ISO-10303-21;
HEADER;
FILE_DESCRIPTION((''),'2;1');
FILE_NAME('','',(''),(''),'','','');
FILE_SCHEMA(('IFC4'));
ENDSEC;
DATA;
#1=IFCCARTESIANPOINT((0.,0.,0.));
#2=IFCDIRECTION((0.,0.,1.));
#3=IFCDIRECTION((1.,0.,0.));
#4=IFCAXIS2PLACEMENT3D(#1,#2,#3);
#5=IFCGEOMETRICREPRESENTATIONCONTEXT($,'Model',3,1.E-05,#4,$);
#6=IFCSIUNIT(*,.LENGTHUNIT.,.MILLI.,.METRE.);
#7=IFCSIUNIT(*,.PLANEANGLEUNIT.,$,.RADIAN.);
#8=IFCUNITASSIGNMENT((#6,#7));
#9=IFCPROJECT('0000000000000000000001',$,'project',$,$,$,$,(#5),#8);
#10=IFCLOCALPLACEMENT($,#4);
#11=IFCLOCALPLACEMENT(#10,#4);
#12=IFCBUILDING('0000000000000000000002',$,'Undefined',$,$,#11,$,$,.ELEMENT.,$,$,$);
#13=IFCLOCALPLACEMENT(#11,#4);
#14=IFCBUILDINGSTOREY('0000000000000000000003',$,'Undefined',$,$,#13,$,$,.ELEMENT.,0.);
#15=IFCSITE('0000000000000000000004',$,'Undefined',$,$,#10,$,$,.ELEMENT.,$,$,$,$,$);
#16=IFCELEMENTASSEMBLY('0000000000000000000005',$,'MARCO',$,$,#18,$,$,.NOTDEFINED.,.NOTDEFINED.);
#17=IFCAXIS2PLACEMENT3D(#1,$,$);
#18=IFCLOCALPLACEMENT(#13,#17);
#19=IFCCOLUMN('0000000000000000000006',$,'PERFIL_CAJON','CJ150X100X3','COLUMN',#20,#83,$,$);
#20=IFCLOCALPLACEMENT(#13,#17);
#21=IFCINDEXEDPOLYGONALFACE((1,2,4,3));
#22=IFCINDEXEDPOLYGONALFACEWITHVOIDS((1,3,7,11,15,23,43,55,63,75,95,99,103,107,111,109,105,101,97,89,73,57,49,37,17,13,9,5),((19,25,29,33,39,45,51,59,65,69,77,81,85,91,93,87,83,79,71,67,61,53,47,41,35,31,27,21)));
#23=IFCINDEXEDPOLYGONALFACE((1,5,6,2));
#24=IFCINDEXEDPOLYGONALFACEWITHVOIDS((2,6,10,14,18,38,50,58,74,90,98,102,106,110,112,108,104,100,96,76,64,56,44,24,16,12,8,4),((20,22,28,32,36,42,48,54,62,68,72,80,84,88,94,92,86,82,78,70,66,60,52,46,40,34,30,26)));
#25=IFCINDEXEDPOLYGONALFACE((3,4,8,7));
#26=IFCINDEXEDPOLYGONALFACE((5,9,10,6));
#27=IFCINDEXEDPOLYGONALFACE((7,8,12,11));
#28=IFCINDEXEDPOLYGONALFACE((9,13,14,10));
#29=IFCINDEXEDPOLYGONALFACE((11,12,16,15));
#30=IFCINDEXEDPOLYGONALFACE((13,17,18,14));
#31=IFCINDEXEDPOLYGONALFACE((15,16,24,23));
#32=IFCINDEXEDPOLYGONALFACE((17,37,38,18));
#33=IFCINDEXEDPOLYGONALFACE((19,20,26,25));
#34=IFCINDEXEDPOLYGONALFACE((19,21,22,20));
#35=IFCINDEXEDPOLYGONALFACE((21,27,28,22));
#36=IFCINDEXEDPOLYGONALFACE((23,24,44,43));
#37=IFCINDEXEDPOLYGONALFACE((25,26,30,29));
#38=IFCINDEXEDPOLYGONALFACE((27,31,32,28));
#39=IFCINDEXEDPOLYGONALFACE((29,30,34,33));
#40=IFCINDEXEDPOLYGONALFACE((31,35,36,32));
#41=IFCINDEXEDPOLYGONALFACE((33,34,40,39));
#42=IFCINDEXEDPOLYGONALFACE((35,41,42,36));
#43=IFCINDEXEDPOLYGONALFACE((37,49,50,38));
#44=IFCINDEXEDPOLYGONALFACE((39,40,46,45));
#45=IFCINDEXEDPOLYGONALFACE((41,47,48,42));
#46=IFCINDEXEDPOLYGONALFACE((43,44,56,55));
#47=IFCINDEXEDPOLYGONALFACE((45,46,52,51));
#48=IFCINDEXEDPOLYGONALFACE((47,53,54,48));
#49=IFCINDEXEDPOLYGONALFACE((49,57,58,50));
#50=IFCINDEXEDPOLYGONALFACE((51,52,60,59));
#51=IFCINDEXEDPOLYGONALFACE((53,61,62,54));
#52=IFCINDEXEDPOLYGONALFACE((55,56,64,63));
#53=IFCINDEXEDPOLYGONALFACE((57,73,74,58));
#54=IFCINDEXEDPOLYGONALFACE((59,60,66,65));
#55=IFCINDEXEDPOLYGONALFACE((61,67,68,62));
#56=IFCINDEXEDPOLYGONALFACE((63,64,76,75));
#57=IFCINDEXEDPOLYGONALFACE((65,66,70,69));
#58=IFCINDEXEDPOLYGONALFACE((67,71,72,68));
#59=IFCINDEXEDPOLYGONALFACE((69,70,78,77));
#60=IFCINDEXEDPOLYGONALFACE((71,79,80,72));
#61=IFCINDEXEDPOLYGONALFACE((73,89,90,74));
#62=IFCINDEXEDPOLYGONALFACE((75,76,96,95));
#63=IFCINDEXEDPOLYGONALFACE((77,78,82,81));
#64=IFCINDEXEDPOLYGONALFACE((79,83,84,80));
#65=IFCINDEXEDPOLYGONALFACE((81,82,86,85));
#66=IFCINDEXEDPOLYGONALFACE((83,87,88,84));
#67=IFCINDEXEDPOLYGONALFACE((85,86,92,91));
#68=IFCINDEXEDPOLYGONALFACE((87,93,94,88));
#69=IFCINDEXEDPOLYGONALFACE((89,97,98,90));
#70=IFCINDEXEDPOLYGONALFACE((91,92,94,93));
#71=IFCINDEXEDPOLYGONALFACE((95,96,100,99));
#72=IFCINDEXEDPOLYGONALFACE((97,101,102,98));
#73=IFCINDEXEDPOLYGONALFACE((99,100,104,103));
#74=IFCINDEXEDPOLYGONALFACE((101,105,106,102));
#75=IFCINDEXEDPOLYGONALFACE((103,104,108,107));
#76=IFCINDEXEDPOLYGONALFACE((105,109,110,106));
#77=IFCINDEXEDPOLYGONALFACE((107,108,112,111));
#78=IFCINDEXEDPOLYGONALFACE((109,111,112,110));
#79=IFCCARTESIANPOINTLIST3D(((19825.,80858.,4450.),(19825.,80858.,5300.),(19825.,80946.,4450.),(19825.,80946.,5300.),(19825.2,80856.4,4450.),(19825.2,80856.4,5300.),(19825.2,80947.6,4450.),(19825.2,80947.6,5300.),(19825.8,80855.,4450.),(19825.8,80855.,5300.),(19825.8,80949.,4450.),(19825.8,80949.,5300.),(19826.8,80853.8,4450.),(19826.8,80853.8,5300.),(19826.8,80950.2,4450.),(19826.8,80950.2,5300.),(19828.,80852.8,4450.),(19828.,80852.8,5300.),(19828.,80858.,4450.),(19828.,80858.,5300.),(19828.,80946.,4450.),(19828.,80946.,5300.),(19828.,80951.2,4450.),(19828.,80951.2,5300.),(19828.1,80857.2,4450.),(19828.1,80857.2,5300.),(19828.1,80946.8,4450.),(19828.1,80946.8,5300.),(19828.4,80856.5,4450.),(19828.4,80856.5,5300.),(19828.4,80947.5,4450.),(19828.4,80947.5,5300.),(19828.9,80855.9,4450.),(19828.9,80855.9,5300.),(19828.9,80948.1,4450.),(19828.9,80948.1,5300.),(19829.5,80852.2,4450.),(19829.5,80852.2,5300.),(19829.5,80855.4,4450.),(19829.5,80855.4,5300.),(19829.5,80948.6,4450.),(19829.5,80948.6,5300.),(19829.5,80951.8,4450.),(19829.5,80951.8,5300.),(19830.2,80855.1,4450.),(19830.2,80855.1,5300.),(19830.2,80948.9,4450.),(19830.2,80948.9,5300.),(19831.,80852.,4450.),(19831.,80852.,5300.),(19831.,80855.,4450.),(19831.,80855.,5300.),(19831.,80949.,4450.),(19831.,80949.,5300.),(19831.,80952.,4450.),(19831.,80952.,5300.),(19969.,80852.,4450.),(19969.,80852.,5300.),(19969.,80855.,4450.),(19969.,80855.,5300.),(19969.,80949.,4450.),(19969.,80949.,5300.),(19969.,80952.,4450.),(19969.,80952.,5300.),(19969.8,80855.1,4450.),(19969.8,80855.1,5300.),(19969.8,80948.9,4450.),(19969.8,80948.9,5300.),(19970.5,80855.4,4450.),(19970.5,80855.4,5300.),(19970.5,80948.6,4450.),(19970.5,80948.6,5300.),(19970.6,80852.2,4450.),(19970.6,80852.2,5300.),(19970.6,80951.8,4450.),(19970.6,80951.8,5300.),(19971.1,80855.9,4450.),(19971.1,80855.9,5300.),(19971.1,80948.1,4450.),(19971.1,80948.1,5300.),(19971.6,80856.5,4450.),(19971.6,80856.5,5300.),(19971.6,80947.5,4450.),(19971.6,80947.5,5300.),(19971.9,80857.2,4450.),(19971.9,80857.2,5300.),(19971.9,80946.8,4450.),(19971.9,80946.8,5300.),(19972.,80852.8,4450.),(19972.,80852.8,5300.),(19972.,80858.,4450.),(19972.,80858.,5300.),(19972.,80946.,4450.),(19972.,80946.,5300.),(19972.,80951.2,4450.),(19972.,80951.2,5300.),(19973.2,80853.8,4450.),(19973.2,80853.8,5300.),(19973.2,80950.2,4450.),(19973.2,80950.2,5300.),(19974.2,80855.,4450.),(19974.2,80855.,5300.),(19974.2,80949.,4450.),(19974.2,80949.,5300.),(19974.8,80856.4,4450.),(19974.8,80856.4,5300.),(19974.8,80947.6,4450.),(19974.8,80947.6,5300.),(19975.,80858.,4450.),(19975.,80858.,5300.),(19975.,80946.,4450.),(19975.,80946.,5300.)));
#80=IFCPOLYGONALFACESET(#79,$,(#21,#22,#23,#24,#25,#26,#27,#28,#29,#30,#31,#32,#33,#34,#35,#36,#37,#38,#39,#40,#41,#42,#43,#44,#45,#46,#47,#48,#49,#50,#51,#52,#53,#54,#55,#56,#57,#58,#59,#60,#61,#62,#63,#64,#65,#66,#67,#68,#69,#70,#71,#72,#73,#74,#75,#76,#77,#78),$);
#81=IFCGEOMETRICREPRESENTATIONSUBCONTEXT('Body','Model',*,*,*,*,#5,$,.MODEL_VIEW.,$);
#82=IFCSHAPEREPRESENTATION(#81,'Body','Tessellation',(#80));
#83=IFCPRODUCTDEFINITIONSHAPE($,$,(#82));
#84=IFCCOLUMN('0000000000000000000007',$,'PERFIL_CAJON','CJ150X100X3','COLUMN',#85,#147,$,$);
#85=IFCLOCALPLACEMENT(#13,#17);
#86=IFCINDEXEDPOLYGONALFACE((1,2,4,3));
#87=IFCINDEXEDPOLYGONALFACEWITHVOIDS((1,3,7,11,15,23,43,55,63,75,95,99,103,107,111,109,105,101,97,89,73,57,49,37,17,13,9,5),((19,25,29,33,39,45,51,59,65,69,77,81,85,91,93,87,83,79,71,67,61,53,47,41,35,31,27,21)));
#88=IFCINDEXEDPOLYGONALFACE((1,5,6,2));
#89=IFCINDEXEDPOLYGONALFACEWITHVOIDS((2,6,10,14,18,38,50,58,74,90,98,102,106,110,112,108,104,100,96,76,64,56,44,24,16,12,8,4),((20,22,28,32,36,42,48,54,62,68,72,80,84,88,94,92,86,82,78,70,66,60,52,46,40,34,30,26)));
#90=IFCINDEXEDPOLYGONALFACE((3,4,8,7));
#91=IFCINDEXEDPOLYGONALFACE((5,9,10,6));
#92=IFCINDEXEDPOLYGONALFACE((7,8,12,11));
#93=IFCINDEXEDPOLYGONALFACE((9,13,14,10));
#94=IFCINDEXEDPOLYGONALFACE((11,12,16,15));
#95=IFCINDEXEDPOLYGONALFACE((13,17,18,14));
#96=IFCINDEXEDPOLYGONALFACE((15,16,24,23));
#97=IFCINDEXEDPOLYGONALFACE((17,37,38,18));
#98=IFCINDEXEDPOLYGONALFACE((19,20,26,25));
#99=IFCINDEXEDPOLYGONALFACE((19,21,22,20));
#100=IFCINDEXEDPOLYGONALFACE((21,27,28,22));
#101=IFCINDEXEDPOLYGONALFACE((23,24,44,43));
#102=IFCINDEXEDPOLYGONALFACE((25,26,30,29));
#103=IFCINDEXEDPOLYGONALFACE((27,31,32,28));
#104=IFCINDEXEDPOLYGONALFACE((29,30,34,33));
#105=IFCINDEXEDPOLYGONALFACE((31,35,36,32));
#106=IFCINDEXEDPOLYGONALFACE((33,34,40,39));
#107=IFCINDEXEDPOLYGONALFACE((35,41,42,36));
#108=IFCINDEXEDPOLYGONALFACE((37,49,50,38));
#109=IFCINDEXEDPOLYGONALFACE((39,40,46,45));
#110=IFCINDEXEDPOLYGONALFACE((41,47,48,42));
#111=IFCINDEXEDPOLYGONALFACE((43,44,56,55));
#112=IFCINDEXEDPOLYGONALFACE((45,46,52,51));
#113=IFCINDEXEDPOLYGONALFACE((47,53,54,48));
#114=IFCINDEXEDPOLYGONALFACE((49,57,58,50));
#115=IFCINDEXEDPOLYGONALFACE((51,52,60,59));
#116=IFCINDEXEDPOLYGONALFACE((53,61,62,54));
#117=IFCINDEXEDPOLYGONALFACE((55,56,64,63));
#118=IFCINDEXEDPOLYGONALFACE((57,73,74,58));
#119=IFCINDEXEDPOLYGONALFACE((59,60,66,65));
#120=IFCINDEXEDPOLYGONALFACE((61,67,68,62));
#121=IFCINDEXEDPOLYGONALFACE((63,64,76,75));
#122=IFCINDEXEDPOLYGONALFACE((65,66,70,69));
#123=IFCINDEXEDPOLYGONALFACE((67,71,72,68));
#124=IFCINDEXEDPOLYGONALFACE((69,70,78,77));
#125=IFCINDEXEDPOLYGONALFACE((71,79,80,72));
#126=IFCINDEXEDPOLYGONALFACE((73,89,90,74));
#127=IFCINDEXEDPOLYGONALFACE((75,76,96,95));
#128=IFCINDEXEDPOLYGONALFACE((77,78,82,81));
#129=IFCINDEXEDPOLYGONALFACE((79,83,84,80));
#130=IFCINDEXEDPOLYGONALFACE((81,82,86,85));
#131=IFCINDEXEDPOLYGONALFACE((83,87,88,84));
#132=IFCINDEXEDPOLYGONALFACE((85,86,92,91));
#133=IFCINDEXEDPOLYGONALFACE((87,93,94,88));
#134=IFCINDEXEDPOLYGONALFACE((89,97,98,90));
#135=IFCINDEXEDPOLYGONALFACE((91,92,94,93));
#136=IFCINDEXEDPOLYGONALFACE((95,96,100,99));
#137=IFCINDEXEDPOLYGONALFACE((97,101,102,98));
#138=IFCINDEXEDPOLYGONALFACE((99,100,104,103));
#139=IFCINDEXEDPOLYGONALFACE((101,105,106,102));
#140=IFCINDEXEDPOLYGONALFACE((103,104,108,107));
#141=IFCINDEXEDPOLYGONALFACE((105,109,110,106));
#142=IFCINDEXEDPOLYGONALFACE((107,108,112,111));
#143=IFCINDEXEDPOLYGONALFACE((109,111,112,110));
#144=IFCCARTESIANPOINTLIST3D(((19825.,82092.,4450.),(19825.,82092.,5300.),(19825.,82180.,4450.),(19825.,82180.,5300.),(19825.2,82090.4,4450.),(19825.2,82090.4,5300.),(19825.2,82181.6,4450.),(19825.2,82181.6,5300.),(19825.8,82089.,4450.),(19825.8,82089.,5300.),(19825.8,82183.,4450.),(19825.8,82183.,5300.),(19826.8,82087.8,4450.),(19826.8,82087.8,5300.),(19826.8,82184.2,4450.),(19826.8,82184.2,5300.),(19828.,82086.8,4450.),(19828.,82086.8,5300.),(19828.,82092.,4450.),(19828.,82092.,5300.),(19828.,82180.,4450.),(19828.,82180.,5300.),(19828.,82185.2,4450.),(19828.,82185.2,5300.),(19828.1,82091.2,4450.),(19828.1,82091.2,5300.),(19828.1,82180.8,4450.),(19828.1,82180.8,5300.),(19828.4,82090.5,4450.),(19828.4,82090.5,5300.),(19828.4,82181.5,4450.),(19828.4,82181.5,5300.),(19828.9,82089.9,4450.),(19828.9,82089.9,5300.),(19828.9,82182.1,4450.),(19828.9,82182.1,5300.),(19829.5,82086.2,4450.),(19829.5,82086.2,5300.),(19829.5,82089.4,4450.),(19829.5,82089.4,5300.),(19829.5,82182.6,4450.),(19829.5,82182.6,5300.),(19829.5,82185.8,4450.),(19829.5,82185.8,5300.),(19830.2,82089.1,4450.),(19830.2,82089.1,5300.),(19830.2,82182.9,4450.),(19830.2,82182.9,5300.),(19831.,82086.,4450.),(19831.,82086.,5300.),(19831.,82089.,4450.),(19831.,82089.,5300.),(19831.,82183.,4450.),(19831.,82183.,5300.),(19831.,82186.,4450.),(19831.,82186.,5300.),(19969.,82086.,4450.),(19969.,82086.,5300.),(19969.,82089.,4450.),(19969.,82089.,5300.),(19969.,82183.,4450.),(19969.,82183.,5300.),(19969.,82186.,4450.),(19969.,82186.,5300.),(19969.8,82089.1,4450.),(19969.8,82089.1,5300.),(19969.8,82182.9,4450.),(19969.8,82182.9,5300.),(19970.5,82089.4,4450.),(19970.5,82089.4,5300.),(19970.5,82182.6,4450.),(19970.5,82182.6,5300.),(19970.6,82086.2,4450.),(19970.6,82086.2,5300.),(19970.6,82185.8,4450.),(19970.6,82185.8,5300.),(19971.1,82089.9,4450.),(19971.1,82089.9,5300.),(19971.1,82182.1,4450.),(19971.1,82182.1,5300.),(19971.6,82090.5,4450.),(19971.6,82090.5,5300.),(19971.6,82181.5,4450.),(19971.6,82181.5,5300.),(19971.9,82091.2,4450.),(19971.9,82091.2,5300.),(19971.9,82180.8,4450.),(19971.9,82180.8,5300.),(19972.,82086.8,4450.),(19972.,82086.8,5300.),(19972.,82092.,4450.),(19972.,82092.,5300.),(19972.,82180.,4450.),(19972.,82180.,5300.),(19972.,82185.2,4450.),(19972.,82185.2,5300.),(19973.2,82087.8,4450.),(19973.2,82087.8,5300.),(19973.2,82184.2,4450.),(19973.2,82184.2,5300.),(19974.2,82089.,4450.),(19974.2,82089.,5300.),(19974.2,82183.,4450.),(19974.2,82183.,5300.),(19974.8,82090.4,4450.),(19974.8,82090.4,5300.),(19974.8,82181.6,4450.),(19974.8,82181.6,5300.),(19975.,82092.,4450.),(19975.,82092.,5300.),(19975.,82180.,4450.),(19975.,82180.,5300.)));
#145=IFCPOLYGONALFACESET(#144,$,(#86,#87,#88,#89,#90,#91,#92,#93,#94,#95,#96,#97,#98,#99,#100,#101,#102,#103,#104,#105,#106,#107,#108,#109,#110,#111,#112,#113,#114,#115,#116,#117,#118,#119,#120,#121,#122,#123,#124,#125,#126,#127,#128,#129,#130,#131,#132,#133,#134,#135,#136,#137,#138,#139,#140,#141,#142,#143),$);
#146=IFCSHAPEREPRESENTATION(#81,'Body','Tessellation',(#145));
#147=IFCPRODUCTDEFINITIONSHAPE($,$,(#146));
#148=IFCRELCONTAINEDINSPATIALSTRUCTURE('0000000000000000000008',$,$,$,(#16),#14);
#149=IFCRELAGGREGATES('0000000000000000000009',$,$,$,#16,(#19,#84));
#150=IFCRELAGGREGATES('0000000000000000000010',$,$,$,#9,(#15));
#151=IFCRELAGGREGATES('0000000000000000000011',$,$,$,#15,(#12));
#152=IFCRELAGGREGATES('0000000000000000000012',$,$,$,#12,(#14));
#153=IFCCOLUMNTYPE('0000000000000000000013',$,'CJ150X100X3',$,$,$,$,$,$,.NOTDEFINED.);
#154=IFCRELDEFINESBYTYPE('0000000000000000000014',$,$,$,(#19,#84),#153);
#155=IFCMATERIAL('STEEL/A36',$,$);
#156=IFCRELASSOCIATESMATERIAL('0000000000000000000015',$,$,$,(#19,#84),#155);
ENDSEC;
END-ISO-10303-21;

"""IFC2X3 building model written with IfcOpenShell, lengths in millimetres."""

from ifc_helpers import new_model, si_unit, frame, origin_with_axes, origin_2d_with_axis, place, context, subcontext, project, spatial, hollow_rectangle, extrude, material, type_object, element, aggregate, save


model = new_model("IFC2X3")

# Units and contexts
model_context = context("Model", 3, precision=1e-05, world=origin_with_axes())
body_context = subcontext(model_context, "Body", "Model", "MODEL_VIEW")
ifc_project = project(units=[si_unit("LENGTHUNIT", "METRE", prefix="MILLI"), si_unit("PLANEANGLEUNIT", "RADIAN")], contexts=[model_context])

# Site, building, storey
site_placement = place(None, origin_with_axes())
site = spatial("IfcSite", under=ifc_project, at=site_placement, Name="Undefined", CompositionType="ELEMENT")
building_placement = place(site_placement, origin_with_axes())
building = spatial("IfcBuilding", under=site, at=building_placement, Name="Undefined", CompositionType="ELEMENT")
storey_placement = place(building_placement, origin_with_axes())
storey = spatial("IfcBuildingStorey", under=building, at=storey_placement, Name="Undefined", CompositionType="ELEMENT", Elevation=0.0)

# Element assembly, columns
assembly_1_placement = place(storey_placement, origin_with_axes())
assembly_1 = element("IfcElementAssembly", 1, at=assembly_1_placement, inside=storey, Name="MARCO", AssemblyPlace="NOTDEFINED", PredefinedType="NOTDEFINED")
ifc_material_1 = material(Name="STEEL/A36")
column_type = type_object("IfcColumnType", Name="CJ150X100X3", PredefinedType="NOTDEFINED")
column_1_placement = place(assembly_1_placement, frame((19900.0, 80902.0, 4450.0), z_axis=(0.0, 0.0, 1.0), x_axis=(-1.0, 0.0, 0.0)))
column_1 = element("IfcColumn", 2, at=column_1_placement, type_object=column_type, material=ifc_material_1, Name="PERFIL_CAJON", Description="CJ150X100X3", ObjectType="COLUMN", context=body_context, shape_type="SweptSolid", body=[
    extrude(hollow_rectangle(XDim=100.0, YDim=150.0, WallThickness=3.0, InnerFilletRadius=3.0, OuterFilletRadius=6.0, at=origin_2d_with_axis()), frame((0.0, 0.0, 850.0), z_axis=(0.0, 0.0, -1.0), x_axis=(0.0, 1.0, 0.0)), (0.0, 0.0, 1.0), 850.0),
])
column_2_placement = place(assembly_1_placement, frame((19900.0, 82136.0, 4450.0), z_axis=(0.0, 0.0, 1.0), x_axis=(-1.0, 0.0, 0.0)))
column_2 = element("IfcColumn", 3, at=column_2_placement, type_object=column_type, material=ifc_material_1, Name="PERFIL_CAJON", Description="CJ150X100X3", ObjectType="COLUMN", context=body_context, shape_type="SweptSolid", body=[
    extrude(hollow_rectangle(XDim=100.0, YDim=150.0, WallThickness=3.0, InnerFilletRadius=3.0, OuterFilletRadius=6.0, at=origin_2d_with_axis()), frame((0.0, 0.0, 850.0), z_axis=(0.0, 0.0, -1.0), x_axis=(0.0, 1.0, 0.0)), (0.0, 0.0, 1.0), 850.0),
])

aggregate(assembly_1, [column_1, column_2])

save(model, "model.ifc")
